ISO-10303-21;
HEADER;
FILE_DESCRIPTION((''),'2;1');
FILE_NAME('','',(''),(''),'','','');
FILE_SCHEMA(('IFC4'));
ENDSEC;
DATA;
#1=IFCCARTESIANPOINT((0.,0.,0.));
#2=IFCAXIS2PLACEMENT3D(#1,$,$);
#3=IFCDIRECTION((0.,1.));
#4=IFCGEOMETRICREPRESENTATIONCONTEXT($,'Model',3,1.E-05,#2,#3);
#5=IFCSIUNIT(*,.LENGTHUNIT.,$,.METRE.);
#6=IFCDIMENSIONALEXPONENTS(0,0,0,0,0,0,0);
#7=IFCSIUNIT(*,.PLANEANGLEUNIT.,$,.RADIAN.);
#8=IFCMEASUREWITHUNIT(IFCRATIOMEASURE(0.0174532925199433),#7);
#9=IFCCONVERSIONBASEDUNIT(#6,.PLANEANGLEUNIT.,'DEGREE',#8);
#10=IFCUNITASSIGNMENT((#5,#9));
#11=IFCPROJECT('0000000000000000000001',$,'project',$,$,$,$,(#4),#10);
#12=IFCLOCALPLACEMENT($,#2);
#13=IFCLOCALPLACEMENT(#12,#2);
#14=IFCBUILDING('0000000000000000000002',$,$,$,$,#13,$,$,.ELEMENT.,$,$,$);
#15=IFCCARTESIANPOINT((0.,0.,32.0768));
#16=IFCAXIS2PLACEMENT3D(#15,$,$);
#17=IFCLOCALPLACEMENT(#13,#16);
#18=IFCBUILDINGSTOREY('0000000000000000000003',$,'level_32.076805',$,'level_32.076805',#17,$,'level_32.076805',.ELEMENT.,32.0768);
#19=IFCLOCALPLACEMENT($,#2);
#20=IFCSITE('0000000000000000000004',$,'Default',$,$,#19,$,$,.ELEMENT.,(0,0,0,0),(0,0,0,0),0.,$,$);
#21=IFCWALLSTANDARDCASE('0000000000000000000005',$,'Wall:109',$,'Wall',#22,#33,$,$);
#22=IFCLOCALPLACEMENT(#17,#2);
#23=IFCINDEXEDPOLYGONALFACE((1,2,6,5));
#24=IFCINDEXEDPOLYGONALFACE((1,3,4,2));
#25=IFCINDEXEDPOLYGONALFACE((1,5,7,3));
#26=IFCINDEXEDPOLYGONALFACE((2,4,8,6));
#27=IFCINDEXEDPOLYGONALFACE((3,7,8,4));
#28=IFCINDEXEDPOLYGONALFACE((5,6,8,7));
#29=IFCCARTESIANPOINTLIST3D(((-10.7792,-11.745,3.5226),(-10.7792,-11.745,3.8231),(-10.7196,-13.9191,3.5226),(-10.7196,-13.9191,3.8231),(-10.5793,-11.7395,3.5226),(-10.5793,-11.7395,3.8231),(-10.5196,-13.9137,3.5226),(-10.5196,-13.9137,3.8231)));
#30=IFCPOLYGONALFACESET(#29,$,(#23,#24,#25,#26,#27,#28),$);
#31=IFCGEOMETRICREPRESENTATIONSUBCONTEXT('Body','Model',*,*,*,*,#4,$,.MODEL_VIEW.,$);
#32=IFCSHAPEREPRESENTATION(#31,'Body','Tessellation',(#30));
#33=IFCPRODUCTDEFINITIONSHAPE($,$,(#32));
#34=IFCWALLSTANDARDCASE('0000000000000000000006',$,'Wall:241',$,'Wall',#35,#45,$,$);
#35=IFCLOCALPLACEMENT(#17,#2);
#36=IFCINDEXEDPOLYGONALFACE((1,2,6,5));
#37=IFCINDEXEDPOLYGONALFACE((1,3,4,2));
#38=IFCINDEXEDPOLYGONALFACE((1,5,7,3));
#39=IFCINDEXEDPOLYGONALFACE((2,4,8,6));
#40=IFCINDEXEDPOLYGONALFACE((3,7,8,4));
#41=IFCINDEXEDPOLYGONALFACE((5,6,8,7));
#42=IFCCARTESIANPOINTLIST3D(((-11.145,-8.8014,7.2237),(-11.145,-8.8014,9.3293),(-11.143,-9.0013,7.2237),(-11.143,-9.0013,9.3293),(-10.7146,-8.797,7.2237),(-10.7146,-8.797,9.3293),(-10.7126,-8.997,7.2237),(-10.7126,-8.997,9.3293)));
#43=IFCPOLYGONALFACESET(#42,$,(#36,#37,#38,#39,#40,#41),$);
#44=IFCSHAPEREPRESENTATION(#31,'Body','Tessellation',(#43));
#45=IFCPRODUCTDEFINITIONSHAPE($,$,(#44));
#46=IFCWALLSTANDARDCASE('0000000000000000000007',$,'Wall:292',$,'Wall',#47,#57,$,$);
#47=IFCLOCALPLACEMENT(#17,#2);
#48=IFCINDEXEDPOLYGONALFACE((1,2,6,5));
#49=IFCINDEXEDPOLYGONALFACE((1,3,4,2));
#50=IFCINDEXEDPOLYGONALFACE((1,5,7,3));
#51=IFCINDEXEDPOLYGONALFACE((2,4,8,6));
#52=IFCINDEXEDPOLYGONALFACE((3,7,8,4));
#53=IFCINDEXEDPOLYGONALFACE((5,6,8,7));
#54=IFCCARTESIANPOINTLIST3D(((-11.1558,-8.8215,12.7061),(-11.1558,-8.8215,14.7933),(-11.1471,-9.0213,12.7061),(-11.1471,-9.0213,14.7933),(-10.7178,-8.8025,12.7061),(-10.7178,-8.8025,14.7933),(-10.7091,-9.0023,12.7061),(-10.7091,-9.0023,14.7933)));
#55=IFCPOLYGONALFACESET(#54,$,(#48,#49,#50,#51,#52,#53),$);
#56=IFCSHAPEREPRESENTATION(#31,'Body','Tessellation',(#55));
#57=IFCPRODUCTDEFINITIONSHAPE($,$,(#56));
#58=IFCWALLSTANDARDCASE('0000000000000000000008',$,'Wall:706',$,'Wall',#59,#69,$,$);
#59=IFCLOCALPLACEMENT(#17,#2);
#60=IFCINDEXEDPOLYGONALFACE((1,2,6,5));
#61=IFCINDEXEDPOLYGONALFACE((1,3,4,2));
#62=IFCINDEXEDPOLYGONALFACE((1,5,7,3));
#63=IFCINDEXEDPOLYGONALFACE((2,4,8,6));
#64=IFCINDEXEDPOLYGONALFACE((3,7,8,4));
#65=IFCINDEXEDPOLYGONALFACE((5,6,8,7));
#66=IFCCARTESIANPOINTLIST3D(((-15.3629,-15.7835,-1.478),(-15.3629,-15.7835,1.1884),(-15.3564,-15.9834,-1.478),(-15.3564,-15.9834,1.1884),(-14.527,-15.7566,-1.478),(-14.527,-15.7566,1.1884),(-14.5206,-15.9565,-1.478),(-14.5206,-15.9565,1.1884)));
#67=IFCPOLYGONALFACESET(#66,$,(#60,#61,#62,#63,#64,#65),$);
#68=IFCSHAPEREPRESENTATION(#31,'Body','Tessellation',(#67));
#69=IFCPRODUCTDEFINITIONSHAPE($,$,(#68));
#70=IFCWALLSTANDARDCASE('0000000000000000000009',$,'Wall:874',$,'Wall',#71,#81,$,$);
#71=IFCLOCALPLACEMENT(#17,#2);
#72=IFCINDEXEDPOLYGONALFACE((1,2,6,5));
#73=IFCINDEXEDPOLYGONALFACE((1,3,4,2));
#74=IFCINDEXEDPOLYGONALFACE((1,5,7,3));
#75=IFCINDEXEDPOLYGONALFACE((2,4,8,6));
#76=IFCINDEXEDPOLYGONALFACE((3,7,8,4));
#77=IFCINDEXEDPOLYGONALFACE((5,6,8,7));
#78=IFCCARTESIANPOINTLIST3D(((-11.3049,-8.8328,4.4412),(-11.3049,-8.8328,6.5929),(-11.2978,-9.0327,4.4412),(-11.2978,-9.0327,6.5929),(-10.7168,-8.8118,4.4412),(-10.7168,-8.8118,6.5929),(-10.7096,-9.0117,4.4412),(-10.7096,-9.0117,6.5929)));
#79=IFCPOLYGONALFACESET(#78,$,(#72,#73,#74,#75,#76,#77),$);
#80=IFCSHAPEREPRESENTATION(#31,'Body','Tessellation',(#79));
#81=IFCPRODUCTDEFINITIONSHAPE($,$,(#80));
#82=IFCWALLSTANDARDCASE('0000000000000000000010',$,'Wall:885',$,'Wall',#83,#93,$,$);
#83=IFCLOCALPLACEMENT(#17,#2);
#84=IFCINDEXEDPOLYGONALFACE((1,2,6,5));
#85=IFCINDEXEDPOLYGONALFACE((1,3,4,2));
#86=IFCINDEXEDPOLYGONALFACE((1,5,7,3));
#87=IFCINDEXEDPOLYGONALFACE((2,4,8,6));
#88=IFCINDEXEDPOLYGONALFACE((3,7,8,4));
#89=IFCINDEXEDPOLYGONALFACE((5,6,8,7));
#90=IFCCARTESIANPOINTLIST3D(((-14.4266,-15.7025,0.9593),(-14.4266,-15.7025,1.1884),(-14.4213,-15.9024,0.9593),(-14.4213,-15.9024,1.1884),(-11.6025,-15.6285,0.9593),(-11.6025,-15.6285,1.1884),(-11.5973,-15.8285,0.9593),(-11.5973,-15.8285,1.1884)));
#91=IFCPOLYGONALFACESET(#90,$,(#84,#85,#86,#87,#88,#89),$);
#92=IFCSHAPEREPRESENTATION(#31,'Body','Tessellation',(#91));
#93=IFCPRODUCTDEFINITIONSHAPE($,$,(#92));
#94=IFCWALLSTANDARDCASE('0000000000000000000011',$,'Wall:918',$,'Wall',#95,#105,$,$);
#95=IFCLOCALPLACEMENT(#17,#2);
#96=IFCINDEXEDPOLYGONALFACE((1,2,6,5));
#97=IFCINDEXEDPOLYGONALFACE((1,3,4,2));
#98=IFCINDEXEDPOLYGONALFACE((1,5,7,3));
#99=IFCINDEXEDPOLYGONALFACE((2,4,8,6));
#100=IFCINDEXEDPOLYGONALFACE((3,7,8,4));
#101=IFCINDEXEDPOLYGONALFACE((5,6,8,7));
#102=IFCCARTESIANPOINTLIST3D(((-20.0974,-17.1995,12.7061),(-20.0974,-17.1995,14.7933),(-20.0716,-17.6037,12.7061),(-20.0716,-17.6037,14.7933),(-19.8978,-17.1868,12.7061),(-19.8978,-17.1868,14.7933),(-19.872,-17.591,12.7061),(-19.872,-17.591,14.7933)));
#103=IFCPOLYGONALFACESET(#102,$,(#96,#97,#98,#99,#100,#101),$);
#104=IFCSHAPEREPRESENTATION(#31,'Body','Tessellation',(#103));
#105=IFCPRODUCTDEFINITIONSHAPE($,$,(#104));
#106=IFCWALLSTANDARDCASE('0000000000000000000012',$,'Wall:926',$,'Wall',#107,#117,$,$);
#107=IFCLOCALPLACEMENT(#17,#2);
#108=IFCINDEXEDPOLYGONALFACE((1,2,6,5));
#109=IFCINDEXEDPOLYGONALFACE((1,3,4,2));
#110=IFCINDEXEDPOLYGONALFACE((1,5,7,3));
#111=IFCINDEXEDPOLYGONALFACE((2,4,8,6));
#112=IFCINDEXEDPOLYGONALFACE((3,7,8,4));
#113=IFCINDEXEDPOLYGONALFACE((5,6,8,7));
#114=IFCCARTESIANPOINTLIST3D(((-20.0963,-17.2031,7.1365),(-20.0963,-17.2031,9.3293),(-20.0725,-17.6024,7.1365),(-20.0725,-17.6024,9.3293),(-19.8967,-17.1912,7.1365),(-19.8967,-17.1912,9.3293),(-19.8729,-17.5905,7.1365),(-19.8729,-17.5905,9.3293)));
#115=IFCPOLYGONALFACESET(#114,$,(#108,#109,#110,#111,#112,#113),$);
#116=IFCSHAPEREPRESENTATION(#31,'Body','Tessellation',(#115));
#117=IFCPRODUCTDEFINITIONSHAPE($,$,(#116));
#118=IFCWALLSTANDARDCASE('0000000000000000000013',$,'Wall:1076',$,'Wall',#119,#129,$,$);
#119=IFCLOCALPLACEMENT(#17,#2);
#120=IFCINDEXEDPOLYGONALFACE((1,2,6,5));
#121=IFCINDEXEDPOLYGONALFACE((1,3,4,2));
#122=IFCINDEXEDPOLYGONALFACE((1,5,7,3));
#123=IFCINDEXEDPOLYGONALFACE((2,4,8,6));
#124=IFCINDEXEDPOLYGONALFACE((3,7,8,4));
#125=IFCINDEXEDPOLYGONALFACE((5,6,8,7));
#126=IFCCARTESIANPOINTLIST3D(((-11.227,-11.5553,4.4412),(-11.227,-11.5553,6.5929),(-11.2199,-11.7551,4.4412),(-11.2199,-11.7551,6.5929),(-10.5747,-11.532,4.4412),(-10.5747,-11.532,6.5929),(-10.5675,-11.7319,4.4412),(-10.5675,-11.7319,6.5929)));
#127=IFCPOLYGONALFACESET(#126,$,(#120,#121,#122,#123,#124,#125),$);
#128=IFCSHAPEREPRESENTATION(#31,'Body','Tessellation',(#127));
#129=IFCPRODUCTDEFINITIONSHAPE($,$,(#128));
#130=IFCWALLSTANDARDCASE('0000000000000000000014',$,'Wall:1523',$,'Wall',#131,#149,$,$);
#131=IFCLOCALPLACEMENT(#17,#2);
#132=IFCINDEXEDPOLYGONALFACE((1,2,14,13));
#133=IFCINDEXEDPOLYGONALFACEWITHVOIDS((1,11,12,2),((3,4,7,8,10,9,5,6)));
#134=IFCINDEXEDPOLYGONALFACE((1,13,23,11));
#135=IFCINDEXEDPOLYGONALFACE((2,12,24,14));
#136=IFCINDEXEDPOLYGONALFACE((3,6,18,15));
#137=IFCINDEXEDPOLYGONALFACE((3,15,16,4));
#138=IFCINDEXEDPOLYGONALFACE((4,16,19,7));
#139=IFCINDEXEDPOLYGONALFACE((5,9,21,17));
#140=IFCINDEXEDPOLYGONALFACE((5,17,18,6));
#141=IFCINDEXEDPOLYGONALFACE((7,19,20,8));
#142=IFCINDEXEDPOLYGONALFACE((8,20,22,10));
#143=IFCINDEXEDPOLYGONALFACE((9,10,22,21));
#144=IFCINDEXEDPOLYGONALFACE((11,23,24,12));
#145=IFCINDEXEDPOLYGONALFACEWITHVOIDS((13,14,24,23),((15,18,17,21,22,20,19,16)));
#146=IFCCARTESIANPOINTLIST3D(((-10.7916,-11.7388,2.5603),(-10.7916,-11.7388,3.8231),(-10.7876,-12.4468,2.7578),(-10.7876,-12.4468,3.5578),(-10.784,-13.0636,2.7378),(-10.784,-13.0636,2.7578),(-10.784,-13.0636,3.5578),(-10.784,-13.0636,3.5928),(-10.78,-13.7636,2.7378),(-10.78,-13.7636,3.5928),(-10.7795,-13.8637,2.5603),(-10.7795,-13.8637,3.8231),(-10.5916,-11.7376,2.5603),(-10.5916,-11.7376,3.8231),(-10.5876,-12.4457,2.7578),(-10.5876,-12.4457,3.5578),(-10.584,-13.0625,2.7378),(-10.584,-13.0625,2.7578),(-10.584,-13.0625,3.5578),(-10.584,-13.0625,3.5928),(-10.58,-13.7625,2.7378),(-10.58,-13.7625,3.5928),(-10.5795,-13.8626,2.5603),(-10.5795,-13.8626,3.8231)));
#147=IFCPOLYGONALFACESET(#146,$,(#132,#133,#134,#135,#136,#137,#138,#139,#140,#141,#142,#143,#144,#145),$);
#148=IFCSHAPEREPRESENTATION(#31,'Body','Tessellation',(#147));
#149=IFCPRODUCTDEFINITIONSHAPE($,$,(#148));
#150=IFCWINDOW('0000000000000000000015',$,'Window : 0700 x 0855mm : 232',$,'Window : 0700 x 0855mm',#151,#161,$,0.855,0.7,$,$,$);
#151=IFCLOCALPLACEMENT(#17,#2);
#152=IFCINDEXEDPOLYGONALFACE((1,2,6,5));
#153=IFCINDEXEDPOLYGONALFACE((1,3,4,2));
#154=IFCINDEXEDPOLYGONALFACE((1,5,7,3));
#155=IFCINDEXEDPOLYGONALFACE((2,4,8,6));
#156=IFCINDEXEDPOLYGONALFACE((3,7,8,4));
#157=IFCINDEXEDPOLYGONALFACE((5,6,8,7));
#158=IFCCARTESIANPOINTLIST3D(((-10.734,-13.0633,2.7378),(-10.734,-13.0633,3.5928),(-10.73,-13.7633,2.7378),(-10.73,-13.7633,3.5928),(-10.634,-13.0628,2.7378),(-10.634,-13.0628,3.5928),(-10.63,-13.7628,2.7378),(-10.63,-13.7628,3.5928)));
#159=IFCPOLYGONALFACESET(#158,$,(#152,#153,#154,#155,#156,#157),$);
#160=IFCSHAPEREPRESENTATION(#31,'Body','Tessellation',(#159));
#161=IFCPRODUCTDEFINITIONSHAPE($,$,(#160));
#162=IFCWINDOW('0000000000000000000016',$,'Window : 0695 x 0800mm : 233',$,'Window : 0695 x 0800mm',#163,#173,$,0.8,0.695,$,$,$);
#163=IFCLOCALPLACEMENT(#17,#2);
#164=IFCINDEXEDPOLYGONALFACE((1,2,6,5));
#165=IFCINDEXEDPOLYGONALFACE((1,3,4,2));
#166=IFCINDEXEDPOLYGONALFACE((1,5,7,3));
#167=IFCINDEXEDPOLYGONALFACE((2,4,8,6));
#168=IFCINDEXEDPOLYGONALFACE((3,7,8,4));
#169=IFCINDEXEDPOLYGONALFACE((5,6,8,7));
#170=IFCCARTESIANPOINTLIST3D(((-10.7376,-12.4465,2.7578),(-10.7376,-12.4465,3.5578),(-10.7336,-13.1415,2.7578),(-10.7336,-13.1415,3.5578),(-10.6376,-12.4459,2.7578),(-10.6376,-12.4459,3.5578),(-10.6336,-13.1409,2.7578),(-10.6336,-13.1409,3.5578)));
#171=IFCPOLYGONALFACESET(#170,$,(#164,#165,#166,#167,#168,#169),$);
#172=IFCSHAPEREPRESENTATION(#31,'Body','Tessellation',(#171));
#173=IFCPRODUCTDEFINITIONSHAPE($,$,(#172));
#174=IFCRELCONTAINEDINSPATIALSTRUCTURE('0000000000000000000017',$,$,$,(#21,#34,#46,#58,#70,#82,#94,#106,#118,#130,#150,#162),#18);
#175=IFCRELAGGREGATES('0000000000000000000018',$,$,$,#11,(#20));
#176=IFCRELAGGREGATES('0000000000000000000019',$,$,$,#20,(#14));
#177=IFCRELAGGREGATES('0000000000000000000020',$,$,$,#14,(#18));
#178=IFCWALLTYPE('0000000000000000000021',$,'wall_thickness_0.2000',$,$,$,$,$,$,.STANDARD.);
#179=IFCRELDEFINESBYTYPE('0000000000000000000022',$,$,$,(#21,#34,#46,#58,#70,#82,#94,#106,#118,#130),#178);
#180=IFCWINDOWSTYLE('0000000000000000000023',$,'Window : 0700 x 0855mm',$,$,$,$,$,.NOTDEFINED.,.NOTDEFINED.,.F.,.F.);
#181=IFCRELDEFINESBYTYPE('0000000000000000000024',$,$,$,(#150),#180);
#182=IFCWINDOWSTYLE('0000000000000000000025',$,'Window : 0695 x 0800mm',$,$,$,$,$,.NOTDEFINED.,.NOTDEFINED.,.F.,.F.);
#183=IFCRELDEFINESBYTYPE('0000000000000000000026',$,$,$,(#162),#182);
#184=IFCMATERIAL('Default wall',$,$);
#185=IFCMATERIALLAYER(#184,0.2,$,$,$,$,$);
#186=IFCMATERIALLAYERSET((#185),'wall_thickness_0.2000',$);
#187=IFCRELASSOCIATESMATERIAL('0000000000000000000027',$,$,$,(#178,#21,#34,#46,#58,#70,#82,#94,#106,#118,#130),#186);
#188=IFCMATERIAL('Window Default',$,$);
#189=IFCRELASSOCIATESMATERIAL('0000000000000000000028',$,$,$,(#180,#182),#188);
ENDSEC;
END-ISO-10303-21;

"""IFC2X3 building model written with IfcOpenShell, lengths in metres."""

from ifc_helpers import new_model, entity, si_unit, converted_unit, direction, frame, frame_2d, origin, origin_2d_with_axis, place, context, subcontext, project, spatial, polyline, rectangle, outline, extrude, source, transform, mapped, material, layer, layer_set, layer_usage, type_object, type_shapes, element, fill, save


model = new_model("IFC2X3")

# Units and contexts
model_context = context("Model", 3, precision=1e-05, world=origin(), true_north=direction((0.0, 1.0)))
body_context = subcontext(model_context, "Body", "Model", "MODEL_VIEW")
ifc_project = project(units=[si_unit("LENGTHUNIT", "METRE"), converted_unit("PLANEANGLEUNIT", "DEGREE", entity("IfcRatioMeasure", 0.0174532925199433), si_unit("PLANEANGLEUNIT", "RADIAN"), dimensions=[0, 0, 0, 0, 0, 0, 0])], contexts=[model_context])

# Site, building, storey
site_placement = place(None, origin())
site = spatial("IfcSite", under=ifc_project, at=site_placement, Name="Default", CompositionType="ELEMENT", RefLatitude=(0, 0, 0, 0), RefLongitude=(0, 0, 0, 0), RefElevation=0.0)
placement_1 = place(None, origin())
building_placement = place(placement_1, origin())
building = spatial("IfcBuilding", under=site, at=building_placement, CompositionType="ELEMENT")
storey_placement = place(building_placement, frame((0.0, 0.0, 32.0768)))
storey = spatial("IfcBuildingStorey", under=building, at=storey_placement, Name="level_32.076805", ObjectType="level_32.076805", LongName="level_32.076805", CompositionType="ELEMENT", Elevation=32.0768)

# Walls
ifc_material_1 = material(Name="Default wall")
ifc_layer = layer(ifc_material_1, 0.2)
ifc_layer_set = layer_set([ifc_layer], Name="wall_thickness_0.2000")
ifc_layer_usage = layer_usage(ifc_layer_set, "AXIS2", "POSITIVE", -0.1)
wall_type = type_object("IfcWallType", Name="wall_thickness_0.2000", PredefinedType="STANDARD", material=ifc_layer_set)
placement_2 = place(building_placement, frame((0.0, 0.0, 35.5994)))
wall_1_placement = place(placement_2, frame((-10.6793, -11.7422, 0.0), z_axis=(0.0, 0.0, 1.0), x_axis=(0.027434, -0.999624, 0.0)))
element("IfcWallStandardCase", 1, at=wall_1_placement, inside=storey, type_object=wall_type, material=ifc_layer_usage, Name="Wall:109", ObjectType="Wall", context=body_context, shape_type="SweptSolid", body=[
    extrude(outline(polyline([(2.175, -0.1), (2.175, 0.1), (0.0, 0.1), (0.0, -0.1), (2.175, -0.1)])), origin(), (0.0, 0.0, 1.0), 0.3005),
])
placement_3 = place(building_placement, frame((0.0, 0.0, 39.3005)))
wall_2_placement = place(placement_3, frame((-10.7136, -8.897, 0.0), z_axis=(0.0, 0.0, 1.0), x_axis=(-0.999949, -0.010104, 0.0)))
element("IfcWallStandardCase", 2, at=wall_2_placement, inside=storey, type_object=wall_type, material=ifc_layer_usage, Name="Wall:241", ObjectType="Wall", context=body_context, shape_type="SweptSolid", body=[
    extrude(outline(polyline([(0.4304, -0.1), (0.4304, 0.1), (0.0, 0.1), (0.0, -0.1), (0.4304, -0.1)])), origin(), (0.0, 0.0, 1.0), 2.1056),
])
placement_4 = place(building_placement, frame((0.0, 0.0, 44.7829)))
wall_3_placement = place(placement_4, frame((-10.7135, -8.9024, 0.0), z_axis=(0.0, 0.0, 1.0), x_axis=(-0.99906, -0.043337, 0.0)))
element("IfcWallStandardCase", 3, at=wall_3_placement, inside=storey, type_object=wall_type, material=ifc_layer_usage, Name="Wall:292", ObjectType="Wall", context=body_context, shape_type="SweptSolid", body=[
    extrude(outline(polyline([(0.4384, -0.1), (0.4384, 0.1), (0.0, 0.1), (0.0, -0.1), (0.4384, -0.1)])), origin(), (0.0, 0.0, 1.0), 2.0872),
])
placement_5 = place(building_placement, frame((0.0, 0.0, 30.5988)))
wall_4_placement = place(placement_5, frame((-14.5238, -15.8565, 0.0), z_axis=(0.0, 0.0, 1.0), x_axis=(-0.999483, -0.032155, 0.0)))
element("IfcWallStandardCase", 4, at=wall_4_placement, inside=storey, type_object=wall_type, material=ifc_layer_usage, Name="Wall:706", ObjectType="Wall", context=body_context, shape_type="SweptSolid", body=[
    extrude(outline(polyline([(0.8363, -0.1), (0.8363, 0.1), (0.0, 0.1), (0.0, -0.1), (0.8363, -0.1)])), origin(), (0.0, 0.0, 1.0), 2.6664),
])
placement_6 = place(building_placement, frame((0.0, 0.0, 36.518)))
wall_5_placement = place(placement_6, frame((-10.7132, -8.9118, 0.0), z_axis=(0.0, 0.0, 1.0), x_axis=(-0.999363, -0.035686, 0.0)))
element("IfcWallStandardCase", 5, at=wall_5_placement, inside=storey, type_object=wall_type, material=ifc_layer_usage, Name="Wall:874", ObjectType="Wall", context=body_context, shape_type="SweptSolid", body=[
    extrude(outline(polyline([(0.5885, -0.1), (0.5885, 0.1), (0.0, 0.1), (0.0, -0.1), (0.5885, -0.1)])), origin(), (0.0, 0.0, 1.0), 2.1518),
])
placement_7 = place(building_placement, frame((0.0, 0.0, 33.0361)))
wall_6_placement = place(placement_7, frame((-14.424, -15.8025, 0.0), z_axis=(0.0, 0.0, 1.0), x_axis=(0.999657, 0.026186, 0.0)))
element("IfcWallStandardCase", 6, at=wall_6_placement, inside=storey, type_object=wall_type, material=ifc_layer_usage, Name="Wall:885", ObjectType="Wall", context=body_context, shape_type="SweptSolid", body=[
    extrude(outline(polyline([(2.825, -0.1), (2.825, 0.1), (0.0, 0.1), (0.0, -0.1), (2.825, -0.1)])), origin(), (0.0, 0.0, 1.0), 0.2291),
])
placement_8 = place(building_placement, frame((0.0, 0.0, 44.7829)))
wall_7_placement = place(placement_8, frame((-19.9976, -17.1932, 0.0), z_axis=(0.0, 0.0, 1.0), x_axis=(0.06371, -0.997968, 0.0)))
element("IfcWallStandardCase", 7, at=wall_7_placement, inside=storey, type_object=wall_type, material=ifc_layer_usage, Name="Wall:918", ObjectType="Wall", context=body_context, shape_type="SweptSolid", body=[
    extrude(outline(polyline([(0.405, -0.1), (0.405, 0.1), (0.0, 0.1), (0.0, -0.1), (0.405, -0.1)])), origin(), (0.0, 0.0, 1.0), 2.0872),
])
placement_9 = place(building_placement, frame((0.0, 0.0, 39.2133)))
wall_8_placement = place(placement_9, frame((-19.9965, -17.1972, 0.0), z_axis=(0.0, 0.0, 1.0), x_axis=(0.059457, -0.998231, 0.0)))
element("IfcWallStandardCase", 8, at=wall_8_placement, inside=storey, type_object=wall_type, material=ifc_layer_usage, Name="Wall:926", ObjectType="Wall", context=body_context, shape_type="SweptSolid", body=[
    extrude(outline(polyline([(0.4, -0.1), (0.4, 0.1), (0.0, 0.1), (0.0, -0.1), (0.4, -0.1)])), origin(), (0.0, 0.0, 1.0), 2.1928),
])
placement_10 = place(building_placement, frame((0.0, 0.0, 36.518)))
wall_9_placement = place(placement_10, frame((-10.5711, -11.6319, 0.0), z_axis=(0.0, 0.0, 1.0), x_axis=(-0.999365, -0.03563, 0.0)))
element("IfcWallStandardCase", 9, at=wall_9_placement, inside=storey, type_object=wall_type, material=ifc_layer_usage, Name="Wall:1076", ObjectType="Wall", context=body_context, shape_type="SweptSolid", body=[
    extrude(outline(polyline([(0.6528, -0.1), (0.6528, 0.1), (0.0, 0.1), (0.0, -0.1), (0.6528, -0.1)])), origin(), (0.0, 0.0, 1.0), 2.1518),
])

# Wall, openings, windows
placement_11 = place(building_placement, frame((0.0, 0.0, 34.6371)))
wall_10_placement = place(placement_11, frame((-10.6795, -13.8632, 0.0), z_axis=(0.0, 0.0, 1.0), x_axis=(-0.005731, 0.999984, 0.0)))
wall_10 = element("IfcWallStandardCase", 10, at=wall_10_placement, inside=storey, type_object=wall_type, material=ifc_layer_usage, Name="Wall:1523", ObjectType="Wall", context=body_context, shape_type="SweptSolid", body=[
    extrude(outline(polyline([(2.125, -0.1), (2.125, 0.1), (0.0, 0.1), (0.0, -0.1), (2.125, -0.1)])), origin(), (0.0, 0.0, 1.0), 1.2628),
])
opening_1_placement = place(wall_10_placement, frame((0.1001, -0.1, 0.1776)))
opening_1 = element("IfcOpeningElement", 11, at=opening_1_placement, cuts=wall_10, ObjectType="Opening", context=body_context, shape_type="SweptSolid", body=[
    extrude(rectangle(XDim=0.7, YDim=0.855, at=frame_2d((0.4275, 0.35), x_axis=(0.0, 1.0))), frame((0.0, 0.0, 0.0), z_axis=(0.0, 1.0, 0.0), x_axis=(0.0, 0.0, 1.0)), (0.0, 0.0, 1.0), 0.2),
])
opening_2_placement = place(wall_10_placement, frame((0.722, -0.1, 0.1976)))
opening_2 = element("IfcOpeningElement", 12, at=opening_2_placement, cuts=wall_10, ObjectType="Opening", context=body_context, shape_type="SweptSolid", body=[
    extrude(rectangle(XDim=0.695, YDim=0.8, at=frame_2d((0.4, 0.3475), x_axis=(0.0, 1.0))), frame((0.0, 0.0, 0.0), z_axis=(0.0, 1.0, 0.0), x_axis=(0.0, 0.0, 1.0)), (0.0, 0.0, 1.0), 0.2),
])
ifc_material_2 = material(Name="Window Default")
window_style_1 = type_object("IfcWindowStyle", Name="Window : 0700 x 0855mm", ConstructionType="NOTDEFINED", OperationType="NOTDEFINED", ParameterTakesPrecedence=False, Sizeable=False, material=ifc_material_2)
shared_shape_1 = source(origin(), body_context, "Body", "SweptSolid", [
    extrude(rectangle(XDim=0.1, YDim=0.7, at=origin_2d_with_axis()), frame((0.35, 0.1, 0.0), z_axis=(0.0, 0.0, 1.0), x_axis=(0.0, 1.0, 0.0)), (0.0, 0.0, 1.0), 0.855),
])
type_shapes(window_style_1, [shared_shape_1])
window_1_placement = place(opening_1_placement, origin())
window_1 = element("IfcWindow", 13, at=window_1_placement, inside=storey, type_object=window_style_1, Name="Window : 0700 x 0855mm : 232", ObjectType="Window : 0700 x 0855mm", OverallHeight=0.855, OverallWidth=0.7, context=body_context, shape_type="MappedRepresentation", body=[
    mapped(shared_shape_1, transform((0.0, 0.0, 0.0), scale=1.0)),
])
fill(opening_1, window_1)
window_style_2 = type_object("IfcWindowStyle", Name="Window : 0695 x 0800mm", ConstructionType="NOTDEFINED", OperationType="NOTDEFINED", ParameterTakesPrecedence=False, Sizeable=False, material=ifc_material_2)
shared_shape_2 = source(origin(), body_context, "Body", "SweptSolid", [
    extrude(rectangle(XDim=0.1, YDim=0.695, at=origin_2d_with_axis()), frame((0.3475, 0.1, 0.0), z_axis=(0.0, 0.0, 1.0), x_axis=(0.0, 1.0, 0.0)), (0.0, 0.0, 1.0), 0.8),
])
type_shapes(window_style_2, [shared_shape_2])
window_2_placement = place(opening_2_placement, origin())
window_2 = element("IfcWindow", 14, at=window_2_placement, inside=storey, type_object=window_style_2, Name="Window : 0695 x 0800mm : 233", ObjectType="Window : 0695 x 0800mm", OverallHeight=0.8, OverallWidth=0.695, context=body_context, shape_type="MappedRepresentation", body=[
    mapped(shared_shape_2, transform((0.0, 0.0, 0.0), scale=1.0)),
])
fill(opening_2, window_2)

save(model, "model.ifc")
